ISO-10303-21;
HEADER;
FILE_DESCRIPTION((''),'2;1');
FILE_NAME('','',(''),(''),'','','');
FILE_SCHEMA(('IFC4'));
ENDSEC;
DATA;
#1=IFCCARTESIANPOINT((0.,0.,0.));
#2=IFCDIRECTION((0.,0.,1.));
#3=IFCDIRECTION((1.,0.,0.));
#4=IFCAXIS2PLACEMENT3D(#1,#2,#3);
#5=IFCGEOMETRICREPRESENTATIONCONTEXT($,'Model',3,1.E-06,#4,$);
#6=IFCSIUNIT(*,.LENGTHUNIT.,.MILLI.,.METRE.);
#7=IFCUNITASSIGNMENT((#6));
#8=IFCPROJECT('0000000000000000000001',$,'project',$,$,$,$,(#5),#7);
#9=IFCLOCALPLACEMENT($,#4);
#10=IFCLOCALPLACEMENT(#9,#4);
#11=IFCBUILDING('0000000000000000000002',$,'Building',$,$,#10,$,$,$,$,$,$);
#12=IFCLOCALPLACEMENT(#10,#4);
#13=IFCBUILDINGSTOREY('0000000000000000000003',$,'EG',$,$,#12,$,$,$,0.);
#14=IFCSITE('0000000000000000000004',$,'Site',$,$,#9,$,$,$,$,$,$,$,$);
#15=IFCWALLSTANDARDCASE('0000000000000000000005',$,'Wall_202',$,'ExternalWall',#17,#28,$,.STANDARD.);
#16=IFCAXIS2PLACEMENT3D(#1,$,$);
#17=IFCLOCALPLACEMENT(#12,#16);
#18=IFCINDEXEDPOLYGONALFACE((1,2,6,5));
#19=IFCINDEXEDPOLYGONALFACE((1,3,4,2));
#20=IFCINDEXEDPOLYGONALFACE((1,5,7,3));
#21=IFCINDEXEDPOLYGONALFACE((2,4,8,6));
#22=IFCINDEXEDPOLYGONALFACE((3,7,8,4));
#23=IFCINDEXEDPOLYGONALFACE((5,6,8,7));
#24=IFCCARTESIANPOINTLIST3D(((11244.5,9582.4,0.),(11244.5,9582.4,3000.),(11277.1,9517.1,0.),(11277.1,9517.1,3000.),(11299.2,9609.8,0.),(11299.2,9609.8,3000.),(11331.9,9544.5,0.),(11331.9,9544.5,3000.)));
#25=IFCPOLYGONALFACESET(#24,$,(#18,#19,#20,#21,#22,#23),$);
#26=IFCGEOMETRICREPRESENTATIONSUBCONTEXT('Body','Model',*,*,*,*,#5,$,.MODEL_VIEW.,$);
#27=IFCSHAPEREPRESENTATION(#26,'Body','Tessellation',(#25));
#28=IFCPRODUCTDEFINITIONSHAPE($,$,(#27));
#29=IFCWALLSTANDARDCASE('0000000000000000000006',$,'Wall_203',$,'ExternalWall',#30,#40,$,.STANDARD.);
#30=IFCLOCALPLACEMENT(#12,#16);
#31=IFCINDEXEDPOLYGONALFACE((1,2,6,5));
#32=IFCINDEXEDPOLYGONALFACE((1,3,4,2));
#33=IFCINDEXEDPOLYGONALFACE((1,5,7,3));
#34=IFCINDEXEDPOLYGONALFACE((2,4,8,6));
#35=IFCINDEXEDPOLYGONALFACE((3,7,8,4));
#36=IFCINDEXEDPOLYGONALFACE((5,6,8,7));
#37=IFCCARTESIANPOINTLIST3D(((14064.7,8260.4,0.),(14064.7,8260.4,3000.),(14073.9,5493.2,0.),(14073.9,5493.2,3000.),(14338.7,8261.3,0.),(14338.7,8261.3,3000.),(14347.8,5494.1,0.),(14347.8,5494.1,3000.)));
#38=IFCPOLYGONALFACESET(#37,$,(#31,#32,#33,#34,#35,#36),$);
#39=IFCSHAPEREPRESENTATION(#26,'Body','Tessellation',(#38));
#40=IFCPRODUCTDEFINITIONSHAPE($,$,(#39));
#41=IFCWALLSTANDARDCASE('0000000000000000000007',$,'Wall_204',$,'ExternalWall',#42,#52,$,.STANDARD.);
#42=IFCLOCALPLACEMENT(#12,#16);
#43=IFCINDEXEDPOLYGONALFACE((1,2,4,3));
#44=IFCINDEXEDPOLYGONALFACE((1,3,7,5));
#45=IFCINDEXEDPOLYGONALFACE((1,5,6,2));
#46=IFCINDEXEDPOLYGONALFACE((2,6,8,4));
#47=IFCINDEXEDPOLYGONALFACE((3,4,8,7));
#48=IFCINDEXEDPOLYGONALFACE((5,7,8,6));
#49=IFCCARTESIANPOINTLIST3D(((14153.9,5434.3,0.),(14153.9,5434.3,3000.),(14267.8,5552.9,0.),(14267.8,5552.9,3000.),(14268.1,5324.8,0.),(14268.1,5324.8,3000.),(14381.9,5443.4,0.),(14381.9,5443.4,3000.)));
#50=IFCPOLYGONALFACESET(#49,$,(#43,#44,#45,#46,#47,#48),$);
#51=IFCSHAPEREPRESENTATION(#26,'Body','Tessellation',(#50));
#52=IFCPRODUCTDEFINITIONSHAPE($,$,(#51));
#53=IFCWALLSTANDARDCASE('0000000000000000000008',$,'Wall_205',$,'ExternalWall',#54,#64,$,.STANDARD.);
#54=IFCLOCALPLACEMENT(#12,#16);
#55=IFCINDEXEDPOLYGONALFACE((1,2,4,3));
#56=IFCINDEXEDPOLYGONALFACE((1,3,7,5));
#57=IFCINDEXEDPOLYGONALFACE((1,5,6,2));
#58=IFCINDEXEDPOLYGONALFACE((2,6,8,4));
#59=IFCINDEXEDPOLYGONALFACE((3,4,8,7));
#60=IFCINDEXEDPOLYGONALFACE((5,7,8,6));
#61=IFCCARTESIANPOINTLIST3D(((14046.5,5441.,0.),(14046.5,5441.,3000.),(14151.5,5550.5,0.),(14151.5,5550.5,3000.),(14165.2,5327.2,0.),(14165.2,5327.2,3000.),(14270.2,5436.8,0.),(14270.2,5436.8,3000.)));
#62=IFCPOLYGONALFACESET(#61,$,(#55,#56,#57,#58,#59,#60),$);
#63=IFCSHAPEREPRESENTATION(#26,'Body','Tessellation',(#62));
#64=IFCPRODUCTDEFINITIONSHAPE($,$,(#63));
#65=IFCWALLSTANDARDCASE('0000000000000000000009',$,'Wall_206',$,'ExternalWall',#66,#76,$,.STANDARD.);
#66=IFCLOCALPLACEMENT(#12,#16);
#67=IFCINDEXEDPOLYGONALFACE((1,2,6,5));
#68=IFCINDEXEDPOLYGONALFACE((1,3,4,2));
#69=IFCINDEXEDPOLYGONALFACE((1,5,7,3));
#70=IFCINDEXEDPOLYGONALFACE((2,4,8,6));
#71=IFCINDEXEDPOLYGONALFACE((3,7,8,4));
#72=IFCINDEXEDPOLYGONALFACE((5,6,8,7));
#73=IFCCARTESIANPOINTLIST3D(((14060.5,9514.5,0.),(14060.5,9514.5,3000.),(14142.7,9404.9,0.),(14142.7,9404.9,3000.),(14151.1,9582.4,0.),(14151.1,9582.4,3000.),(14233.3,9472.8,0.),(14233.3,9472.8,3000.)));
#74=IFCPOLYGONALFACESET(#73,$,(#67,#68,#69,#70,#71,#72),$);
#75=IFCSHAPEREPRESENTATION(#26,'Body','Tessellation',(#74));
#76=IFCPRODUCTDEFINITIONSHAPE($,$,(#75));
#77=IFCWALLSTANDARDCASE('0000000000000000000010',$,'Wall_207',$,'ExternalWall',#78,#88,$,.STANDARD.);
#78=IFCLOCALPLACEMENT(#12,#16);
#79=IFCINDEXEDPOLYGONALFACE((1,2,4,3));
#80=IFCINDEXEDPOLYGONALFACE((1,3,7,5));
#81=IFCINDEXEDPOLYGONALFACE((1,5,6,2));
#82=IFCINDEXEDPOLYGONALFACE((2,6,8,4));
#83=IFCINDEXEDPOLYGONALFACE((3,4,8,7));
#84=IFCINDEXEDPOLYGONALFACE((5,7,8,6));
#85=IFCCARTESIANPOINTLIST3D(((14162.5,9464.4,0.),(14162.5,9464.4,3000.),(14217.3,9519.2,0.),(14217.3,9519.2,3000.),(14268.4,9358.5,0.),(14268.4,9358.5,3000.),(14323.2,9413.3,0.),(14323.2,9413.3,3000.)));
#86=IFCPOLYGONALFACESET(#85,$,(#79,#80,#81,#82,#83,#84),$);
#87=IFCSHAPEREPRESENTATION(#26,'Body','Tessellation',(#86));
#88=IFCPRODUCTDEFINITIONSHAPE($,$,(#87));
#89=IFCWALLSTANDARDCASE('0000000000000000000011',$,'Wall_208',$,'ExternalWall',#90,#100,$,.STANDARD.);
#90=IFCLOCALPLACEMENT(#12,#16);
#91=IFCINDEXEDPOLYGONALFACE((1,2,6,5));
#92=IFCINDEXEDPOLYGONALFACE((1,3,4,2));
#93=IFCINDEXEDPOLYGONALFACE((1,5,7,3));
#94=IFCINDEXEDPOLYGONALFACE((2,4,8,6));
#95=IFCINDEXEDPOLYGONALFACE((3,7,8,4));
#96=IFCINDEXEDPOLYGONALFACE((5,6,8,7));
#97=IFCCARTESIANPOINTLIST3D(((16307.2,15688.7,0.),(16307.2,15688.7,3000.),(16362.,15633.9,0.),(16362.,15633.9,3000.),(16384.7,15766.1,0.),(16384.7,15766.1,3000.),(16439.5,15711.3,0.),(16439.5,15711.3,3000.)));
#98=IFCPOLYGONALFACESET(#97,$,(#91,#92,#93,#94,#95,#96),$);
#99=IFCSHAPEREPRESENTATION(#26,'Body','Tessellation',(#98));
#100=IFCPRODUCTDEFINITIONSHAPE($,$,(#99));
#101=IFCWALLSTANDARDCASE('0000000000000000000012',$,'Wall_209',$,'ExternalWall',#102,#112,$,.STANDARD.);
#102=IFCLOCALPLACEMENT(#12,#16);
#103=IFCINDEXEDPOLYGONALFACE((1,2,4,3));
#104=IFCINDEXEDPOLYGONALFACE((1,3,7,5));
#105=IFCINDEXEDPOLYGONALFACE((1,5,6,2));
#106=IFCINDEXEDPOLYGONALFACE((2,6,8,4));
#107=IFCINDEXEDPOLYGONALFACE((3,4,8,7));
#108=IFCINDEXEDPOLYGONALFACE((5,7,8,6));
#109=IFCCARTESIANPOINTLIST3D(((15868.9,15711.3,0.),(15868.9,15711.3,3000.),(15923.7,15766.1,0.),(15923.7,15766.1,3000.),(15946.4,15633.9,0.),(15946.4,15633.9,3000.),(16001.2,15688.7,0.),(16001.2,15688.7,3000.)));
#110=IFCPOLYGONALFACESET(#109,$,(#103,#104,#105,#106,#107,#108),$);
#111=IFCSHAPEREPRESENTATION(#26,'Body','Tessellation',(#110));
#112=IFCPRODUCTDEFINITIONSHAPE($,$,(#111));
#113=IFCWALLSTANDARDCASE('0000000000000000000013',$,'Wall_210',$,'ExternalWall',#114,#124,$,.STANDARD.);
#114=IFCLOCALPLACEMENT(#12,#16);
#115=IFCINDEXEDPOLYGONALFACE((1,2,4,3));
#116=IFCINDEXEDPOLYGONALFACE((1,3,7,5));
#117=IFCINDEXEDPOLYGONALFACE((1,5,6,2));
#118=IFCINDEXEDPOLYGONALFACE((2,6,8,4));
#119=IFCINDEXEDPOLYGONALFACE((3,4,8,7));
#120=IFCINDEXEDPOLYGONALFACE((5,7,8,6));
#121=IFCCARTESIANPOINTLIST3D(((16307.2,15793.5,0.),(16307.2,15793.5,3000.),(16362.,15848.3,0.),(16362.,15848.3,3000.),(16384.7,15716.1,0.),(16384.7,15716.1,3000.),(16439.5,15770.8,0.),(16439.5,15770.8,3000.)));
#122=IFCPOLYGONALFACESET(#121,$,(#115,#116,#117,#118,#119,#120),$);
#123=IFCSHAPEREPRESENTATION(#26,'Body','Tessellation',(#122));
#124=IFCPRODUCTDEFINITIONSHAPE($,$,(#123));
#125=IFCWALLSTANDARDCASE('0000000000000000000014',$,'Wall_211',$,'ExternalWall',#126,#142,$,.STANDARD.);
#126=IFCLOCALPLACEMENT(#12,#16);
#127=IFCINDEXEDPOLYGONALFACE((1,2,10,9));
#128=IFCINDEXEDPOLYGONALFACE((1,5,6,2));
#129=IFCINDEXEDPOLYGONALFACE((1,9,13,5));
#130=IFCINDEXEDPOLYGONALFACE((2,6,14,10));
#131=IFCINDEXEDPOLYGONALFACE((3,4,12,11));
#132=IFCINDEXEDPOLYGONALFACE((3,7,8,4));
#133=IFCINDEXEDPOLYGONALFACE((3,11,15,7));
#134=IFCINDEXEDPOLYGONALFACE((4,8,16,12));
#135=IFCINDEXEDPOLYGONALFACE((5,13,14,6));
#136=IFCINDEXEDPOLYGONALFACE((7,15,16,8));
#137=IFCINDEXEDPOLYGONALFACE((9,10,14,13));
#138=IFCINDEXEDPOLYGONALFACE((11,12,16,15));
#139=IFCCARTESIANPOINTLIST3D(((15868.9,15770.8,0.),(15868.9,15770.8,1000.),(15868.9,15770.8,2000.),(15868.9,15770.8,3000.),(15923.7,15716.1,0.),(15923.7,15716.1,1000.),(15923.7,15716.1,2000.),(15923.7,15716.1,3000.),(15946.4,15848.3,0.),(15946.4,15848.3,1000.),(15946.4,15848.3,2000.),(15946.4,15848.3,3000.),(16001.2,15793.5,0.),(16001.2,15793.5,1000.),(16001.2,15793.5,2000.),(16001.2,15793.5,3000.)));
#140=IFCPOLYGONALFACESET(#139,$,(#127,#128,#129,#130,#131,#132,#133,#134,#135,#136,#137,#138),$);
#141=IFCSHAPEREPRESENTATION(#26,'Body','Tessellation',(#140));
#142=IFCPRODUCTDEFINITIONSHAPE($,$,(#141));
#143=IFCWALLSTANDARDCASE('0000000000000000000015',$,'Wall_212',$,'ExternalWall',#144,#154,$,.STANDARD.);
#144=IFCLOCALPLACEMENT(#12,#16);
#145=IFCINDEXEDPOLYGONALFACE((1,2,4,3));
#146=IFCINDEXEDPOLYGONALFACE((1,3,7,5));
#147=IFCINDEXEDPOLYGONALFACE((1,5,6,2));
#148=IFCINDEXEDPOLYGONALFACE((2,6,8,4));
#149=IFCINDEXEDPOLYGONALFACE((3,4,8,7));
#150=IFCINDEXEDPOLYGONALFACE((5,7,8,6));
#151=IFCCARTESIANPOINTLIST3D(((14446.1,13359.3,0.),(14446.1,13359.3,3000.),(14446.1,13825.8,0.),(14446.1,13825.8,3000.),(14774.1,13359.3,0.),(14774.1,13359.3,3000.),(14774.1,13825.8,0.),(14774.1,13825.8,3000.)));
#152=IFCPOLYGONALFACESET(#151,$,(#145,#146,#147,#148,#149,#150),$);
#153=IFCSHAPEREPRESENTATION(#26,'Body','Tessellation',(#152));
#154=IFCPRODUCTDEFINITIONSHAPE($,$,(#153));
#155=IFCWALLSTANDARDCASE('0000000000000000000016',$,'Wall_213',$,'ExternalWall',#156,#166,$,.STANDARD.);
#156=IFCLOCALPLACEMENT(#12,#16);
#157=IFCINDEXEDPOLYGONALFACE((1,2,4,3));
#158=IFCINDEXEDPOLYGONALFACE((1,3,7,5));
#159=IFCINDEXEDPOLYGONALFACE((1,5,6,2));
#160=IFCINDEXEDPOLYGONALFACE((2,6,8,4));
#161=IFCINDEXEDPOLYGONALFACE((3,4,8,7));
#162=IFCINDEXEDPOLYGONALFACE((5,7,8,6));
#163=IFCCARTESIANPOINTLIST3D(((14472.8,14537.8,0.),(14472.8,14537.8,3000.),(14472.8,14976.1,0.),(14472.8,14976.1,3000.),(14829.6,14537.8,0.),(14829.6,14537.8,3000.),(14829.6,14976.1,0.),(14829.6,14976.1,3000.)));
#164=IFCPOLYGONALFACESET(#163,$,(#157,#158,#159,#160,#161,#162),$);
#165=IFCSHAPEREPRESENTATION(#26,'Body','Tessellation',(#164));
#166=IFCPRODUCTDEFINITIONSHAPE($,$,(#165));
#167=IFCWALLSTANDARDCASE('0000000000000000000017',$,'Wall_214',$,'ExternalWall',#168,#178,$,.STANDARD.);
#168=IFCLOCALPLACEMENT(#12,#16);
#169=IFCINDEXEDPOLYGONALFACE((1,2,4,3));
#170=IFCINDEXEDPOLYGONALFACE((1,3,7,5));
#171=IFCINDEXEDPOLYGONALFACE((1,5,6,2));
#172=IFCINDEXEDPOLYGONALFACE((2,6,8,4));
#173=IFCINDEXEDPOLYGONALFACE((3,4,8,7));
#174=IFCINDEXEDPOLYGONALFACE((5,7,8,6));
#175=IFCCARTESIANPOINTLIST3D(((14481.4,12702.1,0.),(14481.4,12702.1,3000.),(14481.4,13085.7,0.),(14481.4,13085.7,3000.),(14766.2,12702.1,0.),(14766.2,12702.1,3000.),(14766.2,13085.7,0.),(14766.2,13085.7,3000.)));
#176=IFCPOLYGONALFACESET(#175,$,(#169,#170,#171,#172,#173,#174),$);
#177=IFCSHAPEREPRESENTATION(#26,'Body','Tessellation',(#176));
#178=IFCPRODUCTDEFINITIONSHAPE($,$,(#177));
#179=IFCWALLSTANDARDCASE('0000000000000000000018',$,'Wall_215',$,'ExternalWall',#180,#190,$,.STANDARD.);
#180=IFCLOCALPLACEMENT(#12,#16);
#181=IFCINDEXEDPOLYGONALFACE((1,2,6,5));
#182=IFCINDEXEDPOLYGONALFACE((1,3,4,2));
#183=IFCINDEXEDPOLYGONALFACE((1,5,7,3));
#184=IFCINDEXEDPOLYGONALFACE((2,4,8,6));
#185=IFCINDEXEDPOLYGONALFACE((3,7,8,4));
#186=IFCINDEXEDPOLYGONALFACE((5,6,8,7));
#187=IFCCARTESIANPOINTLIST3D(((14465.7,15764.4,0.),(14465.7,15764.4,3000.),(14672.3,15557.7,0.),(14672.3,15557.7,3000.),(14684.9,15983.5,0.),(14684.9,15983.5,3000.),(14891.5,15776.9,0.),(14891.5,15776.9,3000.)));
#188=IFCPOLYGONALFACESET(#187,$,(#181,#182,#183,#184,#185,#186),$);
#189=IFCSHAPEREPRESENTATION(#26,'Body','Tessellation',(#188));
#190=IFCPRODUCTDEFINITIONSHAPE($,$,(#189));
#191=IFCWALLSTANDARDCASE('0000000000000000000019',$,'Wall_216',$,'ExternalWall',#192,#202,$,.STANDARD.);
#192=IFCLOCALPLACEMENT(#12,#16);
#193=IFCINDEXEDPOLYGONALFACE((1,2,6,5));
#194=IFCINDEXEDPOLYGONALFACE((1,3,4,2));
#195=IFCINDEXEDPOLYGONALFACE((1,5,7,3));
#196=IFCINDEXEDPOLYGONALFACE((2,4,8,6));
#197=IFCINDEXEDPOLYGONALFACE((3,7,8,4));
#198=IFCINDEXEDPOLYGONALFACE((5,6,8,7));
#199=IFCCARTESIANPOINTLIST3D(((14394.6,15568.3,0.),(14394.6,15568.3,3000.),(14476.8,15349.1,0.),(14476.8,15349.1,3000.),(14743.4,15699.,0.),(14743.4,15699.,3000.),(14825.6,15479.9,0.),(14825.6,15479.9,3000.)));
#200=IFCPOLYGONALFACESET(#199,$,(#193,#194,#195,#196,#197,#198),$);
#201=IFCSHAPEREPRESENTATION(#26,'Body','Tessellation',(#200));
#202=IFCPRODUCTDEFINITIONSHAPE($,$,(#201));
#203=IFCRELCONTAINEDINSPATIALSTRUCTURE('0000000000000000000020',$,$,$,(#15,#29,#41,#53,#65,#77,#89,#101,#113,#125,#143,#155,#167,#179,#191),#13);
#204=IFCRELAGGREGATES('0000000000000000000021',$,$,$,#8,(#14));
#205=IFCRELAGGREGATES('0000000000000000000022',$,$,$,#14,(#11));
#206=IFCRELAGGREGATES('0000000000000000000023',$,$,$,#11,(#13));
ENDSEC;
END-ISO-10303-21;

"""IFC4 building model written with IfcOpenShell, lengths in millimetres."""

from ifc_helpers import new_model, si_unit, frame, origin_with_axes, place, context, subcontext, project, spatial, rectangle, extrude, element, save


model = new_model("IFC4")

# Units and contexts
model_context = context("Model", 3, precision=1e-06, world=origin_with_axes())
body_context = subcontext(model_context, "Body", "Model", "MODEL_VIEW")
ifc_project = project(units=[si_unit("LENGTHUNIT", "METRE", prefix="MILLI")], contexts=[model_context])

# Site, building, storey
site_placement = place(None, origin_with_axes())
site = spatial("IfcSite", under=ifc_project, at=site_placement, Name="Site")
building_placement = place(site_placement, origin_with_axes())
building = spatial("IfcBuilding", under=site, at=building_placement, Name="Building")
storey_placement = place(building_placement, origin_with_axes())
storey = spatial("IfcBuildingStorey", under=building, at=storey_placement, Name="EG", Elevation=0.0)

# Walls
wall_1_placement = place(storey_placement, origin_with_axes())
element("IfcWallStandardCase", 1, at=wall_1_placement, inside=storey, Name="Wall_202", ObjectType="ExternalWall", PredefinedType="STANDARD", context=body_context, shape_type="SweptSolid", body=[
    extrude(rectangle(XDim=61.3, YDim=73.1), frame((11288.2, 9563.4, 0.0), z_axis=(0.0, 0.0, 1.0), x_axis=(0.894427, 0.447214, 0.0)), (0.0, 0.0, 1.0), 3000.0),
])
wall_2_placement = place(storey_placement, origin_with_axes())
element("IfcWallStandardCase", 2, at=wall_2_placement, inside=storey, Name="Wall_203", ObjectType="ExternalWall", PredefinedType="STANDARD", context=body_context, shape_type="SweptSolid", body=[
    extrude(rectangle(XDim=2767.2, YDim=274.0), frame((14206.3, 6877.2, 0.0), z_axis=(0.0, 0.0, 1.0), x_axis=(0.0033, -0.999995, 0.0)), (0.0, 0.0, 1.0), 3000.0),
])
wall_3_placement = place(storey_placement, origin_with_axes())
element("IfcWallStandardCase", 3, at=wall_3_placement, inside=storey, Name="Wall_204", ObjectType="ExternalWall", PredefinedType="STANDARD", context=body_context, shape_type="SweptSolid", body=[
    extrude(rectangle(XDim=158.2, YDim=164.4), frame((14267.9, 5438.9, 0.0), z_axis=(0.0, 0.0, 1.0), x_axis=(0.721459, -0.692457, 0.0)), (0.0, 0.0, 1.0), 3000.0),
])
wall_4_placement = place(storey_placement, origin_with_axes())
element("IfcWallStandardCase", 4, at=wall_4_placement, inside=storey, Name="Wall_205", ObjectType="ExternalWall", PredefinedType="STANDARD", context=body_context, shape_type="SweptSolid", body=[
    extrude(rectangle(XDim=151.8, YDim=164.4), frame((14158.3, 5438.9, 0.0), z_axis=(0.0, 0.0, 1.0), x_axis=(-0.69198, -0.721917, 0.0)), (0.0, 0.0, 1.0), 3000.0),
])
wall_5_placement = place(storey_placement, origin_with_axes())
element("IfcWallStandardCase", 5, at=wall_5_placement, inside=storey, Name="Wall_206", ObjectType="ExternalWall", PredefinedType="STANDARD", context=body_context, shape_type="SweptSolid", body=[
    extrude(rectangle(XDim=137.0, YDim=113.2), frame((14146.9, 9493.7, 0.0), z_axis=(0.0, 0.0, 1.0), x_axis=(-0.6, 0.8, 0.0)), (0.0, 0.0, 1.0), 3000.0),
])
wall_6_placement = place(storey_placement, origin_with_axes())
element("IfcWallStandardCase", 6, at=wall_6_placement, inside=storey, Name="Wall_207", ObjectType="ExternalWall", PredefinedType="STANDARD", context=body_context, shape_type="SweptSolid", body=[
    extrude(rectangle(XDim=77.5, YDim=149.8), frame((14242.8, 9438.9, 0.0), z_axis=(0.0, 0.0, 1.0), x_axis=(0.707107, 0.707107, 0.0)), (0.0, 0.0, 1.0), 3000.0),
])
wall_7_placement = place(storey_placement, origin_with_axes())
element("IfcWallStandardCase", 7, at=wall_7_placement, inside=storey, Name="Wall_208", ObjectType="ExternalWall", PredefinedType="STANDARD", context=body_context, shape_type="SweptSolid", body=[
    extrude(rectangle(XDim=77.5, YDim=109.6), frame((16373.4, 15700.0, 0.0), z_axis=(0.0, 0.0, 1.0), x_axis=(0.707107, -0.707107, 0.0)), (0.0, 0.0, 1.0), 3000.0),
])
wall_8_placement = place(storey_placement, origin_with_axes())
element("IfcWallStandardCase", 8, at=wall_8_placement, inside=storey, Name="Wall_209", ObjectType="ExternalWall", PredefinedType="STANDARD", context=body_context, shape_type="SweptSolid", body=[
    extrude(rectangle(XDim=77.5, YDim=109.6), frame((15935.0, 15700.0, 0.0), z_axis=(0.0, 0.0, 1.0), x_axis=(-0.707107, -0.707107, 0.0)), (0.0, 0.0, 1.0), 3000.0),
])
wall_9_placement = place(storey_placement, origin_with_axes())
element("IfcWallStandardCase", 9, at=wall_9_placement, inside=storey, Name="Wall_210", ObjectType="ExternalWall", PredefinedType="STANDARD", context=body_context, shape_type="SweptSolid", body=[
    extrude(rectangle(XDim=77.5, YDim=109.6), frame((16373.4, 15782.2, 0.0), z_axis=(0.0, 0.0, 1.0), x_axis=(-0.707107, -0.707107, 0.0)), (0.0, 0.0, 1.0), 3000.0),
])

# Wall, opening
wall_10_placement = place(storey_placement, origin_with_axes())
wall_10 = element("IfcWallStandardCase", 10, at=wall_10_placement, inside=storey, Name="Wall_211", ObjectType="ExternalWall", PredefinedType="STANDARD", context=body_context, shape_type="SweptSolid", body=[
    extrude(rectangle(XDim=77.5, YDim=109.6), frame((15935.0, 15782.2, 0.0), z_axis=(0.0, 0.0, 1.0), x_axis=(-0.707107, 0.707107, 0.0)), (0.0, 0.0, 1.0), 3000.0),
])
opening_placement = place(wall_10_placement, origin_with_axes())
element("IfcOpeningElement", 11, at=opening_placement, inside=storey, cuts=wall_10, context=body_context, shape_type="SweptSolid", body=[
    extrude(rectangle(XDim=600.0, YDim=109.6), frame((15928.8, 15788.4, 1000.0), z_axis=(0.0, 0.0, 1.0), x_axis=(-0.707107, 0.707107, 0.0)), (0.0, 0.0, 1.0), 1000.0),
])

# Walls
wall_11_placement = place(storey_placement, origin_with_axes())
element("IfcWallStandardCase", 12, at=wall_11_placement, inside=storey, Name="Wall_212", ObjectType="ExternalWall", PredefinedType="STANDARD", context=body_context, shape_type="SweptSolid", body=[
    extrude(rectangle(XDim=466.6, YDim=328.0), frame((14610.1, 13592.6, 0.0), z_axis=(0.0, 0.0, 1.0), x_axis=(0.0, 1.0, 0.0)), (0.0, 0.0, 1.0), 3000.0),
])
wall_12_placement = place(storey_placement, origin_with_axes())
element("IfcWallStandardCase", 13, at=wall_12_placement, inside=storey, Name="Wall_213", ObjectType="ExternalWall", PredefinedType="STANDARD", context=body_context, shape_type="SweptSolid", body=[
    extrude(rectangle(XDim=438.4, YDim=356.8), frame((14651.2, 14756.9, 0.0), z_axis=(0.0, 0.0, 1.0), x_axis=(0.0, 1.0, 0.0)), (0.0, 0.0, 1.0), 3000.0),
])
wall_13_placement = place(storey_placement, origin_with_axes())
element("IfcWallStandardCase", 14, at=wall_13_placement, inside=storey, Name="Wall_214", ObjectType="ExternalWall", PredefinedType="STANDARD", context=body_context, shape_type="SweptSolid", body=[
    extrude(rectangle(XDim=383.6, YDim=284.8), frame((14623.8, 12893.9, 0.0), z_axis=(0.0, 0.0, 1.0), x_axis=(0.0, 1.0, 0.0)), (0.0, 0.0, 1.0), 3000.0),
])
wall_14_placement = place(storey_placement, origin_with_axes())
element("IfcWallStandardCase", 15, at=wall_14_placement, inside=storey, Name="Wall_215", ObjectType="ExternalWall", PredefinedType="STANDARD", context=body_context, shape_type="SweptSolid", body=[
    extrude(rectangle(XDim=310.0, YDim=292.2), frame((14678.6, 15770.6, 0.0), z_axis=(0.0, 0.0, 1.0), x_axis=(0.707107, 0.707107, 0.0)), (0.0, 0.0, 1.0), 3000.0),
])
wall_15_placement = place(storey_placement, origin_with_axes())
element("IfcWallStandardCase", 16, at=wall_15_placement, inside=storey, Name="Wall_216", ObjectType="ExternalWall", PredefinedType="STANDARD", context=body_context, shape_type="SweptSolid", body=[
    extrude(rectangle(XDim=234.1, YDim=372.5), frame((14610.1, 15524.1, 0.0), z_axis=(0.0, 0.0, 1.0), x_axis=(-0.351123, 0.936329, 0.0)), (0.0, 0.0, 1.0), 3000.0),
])

save(model, "model.ifc")
